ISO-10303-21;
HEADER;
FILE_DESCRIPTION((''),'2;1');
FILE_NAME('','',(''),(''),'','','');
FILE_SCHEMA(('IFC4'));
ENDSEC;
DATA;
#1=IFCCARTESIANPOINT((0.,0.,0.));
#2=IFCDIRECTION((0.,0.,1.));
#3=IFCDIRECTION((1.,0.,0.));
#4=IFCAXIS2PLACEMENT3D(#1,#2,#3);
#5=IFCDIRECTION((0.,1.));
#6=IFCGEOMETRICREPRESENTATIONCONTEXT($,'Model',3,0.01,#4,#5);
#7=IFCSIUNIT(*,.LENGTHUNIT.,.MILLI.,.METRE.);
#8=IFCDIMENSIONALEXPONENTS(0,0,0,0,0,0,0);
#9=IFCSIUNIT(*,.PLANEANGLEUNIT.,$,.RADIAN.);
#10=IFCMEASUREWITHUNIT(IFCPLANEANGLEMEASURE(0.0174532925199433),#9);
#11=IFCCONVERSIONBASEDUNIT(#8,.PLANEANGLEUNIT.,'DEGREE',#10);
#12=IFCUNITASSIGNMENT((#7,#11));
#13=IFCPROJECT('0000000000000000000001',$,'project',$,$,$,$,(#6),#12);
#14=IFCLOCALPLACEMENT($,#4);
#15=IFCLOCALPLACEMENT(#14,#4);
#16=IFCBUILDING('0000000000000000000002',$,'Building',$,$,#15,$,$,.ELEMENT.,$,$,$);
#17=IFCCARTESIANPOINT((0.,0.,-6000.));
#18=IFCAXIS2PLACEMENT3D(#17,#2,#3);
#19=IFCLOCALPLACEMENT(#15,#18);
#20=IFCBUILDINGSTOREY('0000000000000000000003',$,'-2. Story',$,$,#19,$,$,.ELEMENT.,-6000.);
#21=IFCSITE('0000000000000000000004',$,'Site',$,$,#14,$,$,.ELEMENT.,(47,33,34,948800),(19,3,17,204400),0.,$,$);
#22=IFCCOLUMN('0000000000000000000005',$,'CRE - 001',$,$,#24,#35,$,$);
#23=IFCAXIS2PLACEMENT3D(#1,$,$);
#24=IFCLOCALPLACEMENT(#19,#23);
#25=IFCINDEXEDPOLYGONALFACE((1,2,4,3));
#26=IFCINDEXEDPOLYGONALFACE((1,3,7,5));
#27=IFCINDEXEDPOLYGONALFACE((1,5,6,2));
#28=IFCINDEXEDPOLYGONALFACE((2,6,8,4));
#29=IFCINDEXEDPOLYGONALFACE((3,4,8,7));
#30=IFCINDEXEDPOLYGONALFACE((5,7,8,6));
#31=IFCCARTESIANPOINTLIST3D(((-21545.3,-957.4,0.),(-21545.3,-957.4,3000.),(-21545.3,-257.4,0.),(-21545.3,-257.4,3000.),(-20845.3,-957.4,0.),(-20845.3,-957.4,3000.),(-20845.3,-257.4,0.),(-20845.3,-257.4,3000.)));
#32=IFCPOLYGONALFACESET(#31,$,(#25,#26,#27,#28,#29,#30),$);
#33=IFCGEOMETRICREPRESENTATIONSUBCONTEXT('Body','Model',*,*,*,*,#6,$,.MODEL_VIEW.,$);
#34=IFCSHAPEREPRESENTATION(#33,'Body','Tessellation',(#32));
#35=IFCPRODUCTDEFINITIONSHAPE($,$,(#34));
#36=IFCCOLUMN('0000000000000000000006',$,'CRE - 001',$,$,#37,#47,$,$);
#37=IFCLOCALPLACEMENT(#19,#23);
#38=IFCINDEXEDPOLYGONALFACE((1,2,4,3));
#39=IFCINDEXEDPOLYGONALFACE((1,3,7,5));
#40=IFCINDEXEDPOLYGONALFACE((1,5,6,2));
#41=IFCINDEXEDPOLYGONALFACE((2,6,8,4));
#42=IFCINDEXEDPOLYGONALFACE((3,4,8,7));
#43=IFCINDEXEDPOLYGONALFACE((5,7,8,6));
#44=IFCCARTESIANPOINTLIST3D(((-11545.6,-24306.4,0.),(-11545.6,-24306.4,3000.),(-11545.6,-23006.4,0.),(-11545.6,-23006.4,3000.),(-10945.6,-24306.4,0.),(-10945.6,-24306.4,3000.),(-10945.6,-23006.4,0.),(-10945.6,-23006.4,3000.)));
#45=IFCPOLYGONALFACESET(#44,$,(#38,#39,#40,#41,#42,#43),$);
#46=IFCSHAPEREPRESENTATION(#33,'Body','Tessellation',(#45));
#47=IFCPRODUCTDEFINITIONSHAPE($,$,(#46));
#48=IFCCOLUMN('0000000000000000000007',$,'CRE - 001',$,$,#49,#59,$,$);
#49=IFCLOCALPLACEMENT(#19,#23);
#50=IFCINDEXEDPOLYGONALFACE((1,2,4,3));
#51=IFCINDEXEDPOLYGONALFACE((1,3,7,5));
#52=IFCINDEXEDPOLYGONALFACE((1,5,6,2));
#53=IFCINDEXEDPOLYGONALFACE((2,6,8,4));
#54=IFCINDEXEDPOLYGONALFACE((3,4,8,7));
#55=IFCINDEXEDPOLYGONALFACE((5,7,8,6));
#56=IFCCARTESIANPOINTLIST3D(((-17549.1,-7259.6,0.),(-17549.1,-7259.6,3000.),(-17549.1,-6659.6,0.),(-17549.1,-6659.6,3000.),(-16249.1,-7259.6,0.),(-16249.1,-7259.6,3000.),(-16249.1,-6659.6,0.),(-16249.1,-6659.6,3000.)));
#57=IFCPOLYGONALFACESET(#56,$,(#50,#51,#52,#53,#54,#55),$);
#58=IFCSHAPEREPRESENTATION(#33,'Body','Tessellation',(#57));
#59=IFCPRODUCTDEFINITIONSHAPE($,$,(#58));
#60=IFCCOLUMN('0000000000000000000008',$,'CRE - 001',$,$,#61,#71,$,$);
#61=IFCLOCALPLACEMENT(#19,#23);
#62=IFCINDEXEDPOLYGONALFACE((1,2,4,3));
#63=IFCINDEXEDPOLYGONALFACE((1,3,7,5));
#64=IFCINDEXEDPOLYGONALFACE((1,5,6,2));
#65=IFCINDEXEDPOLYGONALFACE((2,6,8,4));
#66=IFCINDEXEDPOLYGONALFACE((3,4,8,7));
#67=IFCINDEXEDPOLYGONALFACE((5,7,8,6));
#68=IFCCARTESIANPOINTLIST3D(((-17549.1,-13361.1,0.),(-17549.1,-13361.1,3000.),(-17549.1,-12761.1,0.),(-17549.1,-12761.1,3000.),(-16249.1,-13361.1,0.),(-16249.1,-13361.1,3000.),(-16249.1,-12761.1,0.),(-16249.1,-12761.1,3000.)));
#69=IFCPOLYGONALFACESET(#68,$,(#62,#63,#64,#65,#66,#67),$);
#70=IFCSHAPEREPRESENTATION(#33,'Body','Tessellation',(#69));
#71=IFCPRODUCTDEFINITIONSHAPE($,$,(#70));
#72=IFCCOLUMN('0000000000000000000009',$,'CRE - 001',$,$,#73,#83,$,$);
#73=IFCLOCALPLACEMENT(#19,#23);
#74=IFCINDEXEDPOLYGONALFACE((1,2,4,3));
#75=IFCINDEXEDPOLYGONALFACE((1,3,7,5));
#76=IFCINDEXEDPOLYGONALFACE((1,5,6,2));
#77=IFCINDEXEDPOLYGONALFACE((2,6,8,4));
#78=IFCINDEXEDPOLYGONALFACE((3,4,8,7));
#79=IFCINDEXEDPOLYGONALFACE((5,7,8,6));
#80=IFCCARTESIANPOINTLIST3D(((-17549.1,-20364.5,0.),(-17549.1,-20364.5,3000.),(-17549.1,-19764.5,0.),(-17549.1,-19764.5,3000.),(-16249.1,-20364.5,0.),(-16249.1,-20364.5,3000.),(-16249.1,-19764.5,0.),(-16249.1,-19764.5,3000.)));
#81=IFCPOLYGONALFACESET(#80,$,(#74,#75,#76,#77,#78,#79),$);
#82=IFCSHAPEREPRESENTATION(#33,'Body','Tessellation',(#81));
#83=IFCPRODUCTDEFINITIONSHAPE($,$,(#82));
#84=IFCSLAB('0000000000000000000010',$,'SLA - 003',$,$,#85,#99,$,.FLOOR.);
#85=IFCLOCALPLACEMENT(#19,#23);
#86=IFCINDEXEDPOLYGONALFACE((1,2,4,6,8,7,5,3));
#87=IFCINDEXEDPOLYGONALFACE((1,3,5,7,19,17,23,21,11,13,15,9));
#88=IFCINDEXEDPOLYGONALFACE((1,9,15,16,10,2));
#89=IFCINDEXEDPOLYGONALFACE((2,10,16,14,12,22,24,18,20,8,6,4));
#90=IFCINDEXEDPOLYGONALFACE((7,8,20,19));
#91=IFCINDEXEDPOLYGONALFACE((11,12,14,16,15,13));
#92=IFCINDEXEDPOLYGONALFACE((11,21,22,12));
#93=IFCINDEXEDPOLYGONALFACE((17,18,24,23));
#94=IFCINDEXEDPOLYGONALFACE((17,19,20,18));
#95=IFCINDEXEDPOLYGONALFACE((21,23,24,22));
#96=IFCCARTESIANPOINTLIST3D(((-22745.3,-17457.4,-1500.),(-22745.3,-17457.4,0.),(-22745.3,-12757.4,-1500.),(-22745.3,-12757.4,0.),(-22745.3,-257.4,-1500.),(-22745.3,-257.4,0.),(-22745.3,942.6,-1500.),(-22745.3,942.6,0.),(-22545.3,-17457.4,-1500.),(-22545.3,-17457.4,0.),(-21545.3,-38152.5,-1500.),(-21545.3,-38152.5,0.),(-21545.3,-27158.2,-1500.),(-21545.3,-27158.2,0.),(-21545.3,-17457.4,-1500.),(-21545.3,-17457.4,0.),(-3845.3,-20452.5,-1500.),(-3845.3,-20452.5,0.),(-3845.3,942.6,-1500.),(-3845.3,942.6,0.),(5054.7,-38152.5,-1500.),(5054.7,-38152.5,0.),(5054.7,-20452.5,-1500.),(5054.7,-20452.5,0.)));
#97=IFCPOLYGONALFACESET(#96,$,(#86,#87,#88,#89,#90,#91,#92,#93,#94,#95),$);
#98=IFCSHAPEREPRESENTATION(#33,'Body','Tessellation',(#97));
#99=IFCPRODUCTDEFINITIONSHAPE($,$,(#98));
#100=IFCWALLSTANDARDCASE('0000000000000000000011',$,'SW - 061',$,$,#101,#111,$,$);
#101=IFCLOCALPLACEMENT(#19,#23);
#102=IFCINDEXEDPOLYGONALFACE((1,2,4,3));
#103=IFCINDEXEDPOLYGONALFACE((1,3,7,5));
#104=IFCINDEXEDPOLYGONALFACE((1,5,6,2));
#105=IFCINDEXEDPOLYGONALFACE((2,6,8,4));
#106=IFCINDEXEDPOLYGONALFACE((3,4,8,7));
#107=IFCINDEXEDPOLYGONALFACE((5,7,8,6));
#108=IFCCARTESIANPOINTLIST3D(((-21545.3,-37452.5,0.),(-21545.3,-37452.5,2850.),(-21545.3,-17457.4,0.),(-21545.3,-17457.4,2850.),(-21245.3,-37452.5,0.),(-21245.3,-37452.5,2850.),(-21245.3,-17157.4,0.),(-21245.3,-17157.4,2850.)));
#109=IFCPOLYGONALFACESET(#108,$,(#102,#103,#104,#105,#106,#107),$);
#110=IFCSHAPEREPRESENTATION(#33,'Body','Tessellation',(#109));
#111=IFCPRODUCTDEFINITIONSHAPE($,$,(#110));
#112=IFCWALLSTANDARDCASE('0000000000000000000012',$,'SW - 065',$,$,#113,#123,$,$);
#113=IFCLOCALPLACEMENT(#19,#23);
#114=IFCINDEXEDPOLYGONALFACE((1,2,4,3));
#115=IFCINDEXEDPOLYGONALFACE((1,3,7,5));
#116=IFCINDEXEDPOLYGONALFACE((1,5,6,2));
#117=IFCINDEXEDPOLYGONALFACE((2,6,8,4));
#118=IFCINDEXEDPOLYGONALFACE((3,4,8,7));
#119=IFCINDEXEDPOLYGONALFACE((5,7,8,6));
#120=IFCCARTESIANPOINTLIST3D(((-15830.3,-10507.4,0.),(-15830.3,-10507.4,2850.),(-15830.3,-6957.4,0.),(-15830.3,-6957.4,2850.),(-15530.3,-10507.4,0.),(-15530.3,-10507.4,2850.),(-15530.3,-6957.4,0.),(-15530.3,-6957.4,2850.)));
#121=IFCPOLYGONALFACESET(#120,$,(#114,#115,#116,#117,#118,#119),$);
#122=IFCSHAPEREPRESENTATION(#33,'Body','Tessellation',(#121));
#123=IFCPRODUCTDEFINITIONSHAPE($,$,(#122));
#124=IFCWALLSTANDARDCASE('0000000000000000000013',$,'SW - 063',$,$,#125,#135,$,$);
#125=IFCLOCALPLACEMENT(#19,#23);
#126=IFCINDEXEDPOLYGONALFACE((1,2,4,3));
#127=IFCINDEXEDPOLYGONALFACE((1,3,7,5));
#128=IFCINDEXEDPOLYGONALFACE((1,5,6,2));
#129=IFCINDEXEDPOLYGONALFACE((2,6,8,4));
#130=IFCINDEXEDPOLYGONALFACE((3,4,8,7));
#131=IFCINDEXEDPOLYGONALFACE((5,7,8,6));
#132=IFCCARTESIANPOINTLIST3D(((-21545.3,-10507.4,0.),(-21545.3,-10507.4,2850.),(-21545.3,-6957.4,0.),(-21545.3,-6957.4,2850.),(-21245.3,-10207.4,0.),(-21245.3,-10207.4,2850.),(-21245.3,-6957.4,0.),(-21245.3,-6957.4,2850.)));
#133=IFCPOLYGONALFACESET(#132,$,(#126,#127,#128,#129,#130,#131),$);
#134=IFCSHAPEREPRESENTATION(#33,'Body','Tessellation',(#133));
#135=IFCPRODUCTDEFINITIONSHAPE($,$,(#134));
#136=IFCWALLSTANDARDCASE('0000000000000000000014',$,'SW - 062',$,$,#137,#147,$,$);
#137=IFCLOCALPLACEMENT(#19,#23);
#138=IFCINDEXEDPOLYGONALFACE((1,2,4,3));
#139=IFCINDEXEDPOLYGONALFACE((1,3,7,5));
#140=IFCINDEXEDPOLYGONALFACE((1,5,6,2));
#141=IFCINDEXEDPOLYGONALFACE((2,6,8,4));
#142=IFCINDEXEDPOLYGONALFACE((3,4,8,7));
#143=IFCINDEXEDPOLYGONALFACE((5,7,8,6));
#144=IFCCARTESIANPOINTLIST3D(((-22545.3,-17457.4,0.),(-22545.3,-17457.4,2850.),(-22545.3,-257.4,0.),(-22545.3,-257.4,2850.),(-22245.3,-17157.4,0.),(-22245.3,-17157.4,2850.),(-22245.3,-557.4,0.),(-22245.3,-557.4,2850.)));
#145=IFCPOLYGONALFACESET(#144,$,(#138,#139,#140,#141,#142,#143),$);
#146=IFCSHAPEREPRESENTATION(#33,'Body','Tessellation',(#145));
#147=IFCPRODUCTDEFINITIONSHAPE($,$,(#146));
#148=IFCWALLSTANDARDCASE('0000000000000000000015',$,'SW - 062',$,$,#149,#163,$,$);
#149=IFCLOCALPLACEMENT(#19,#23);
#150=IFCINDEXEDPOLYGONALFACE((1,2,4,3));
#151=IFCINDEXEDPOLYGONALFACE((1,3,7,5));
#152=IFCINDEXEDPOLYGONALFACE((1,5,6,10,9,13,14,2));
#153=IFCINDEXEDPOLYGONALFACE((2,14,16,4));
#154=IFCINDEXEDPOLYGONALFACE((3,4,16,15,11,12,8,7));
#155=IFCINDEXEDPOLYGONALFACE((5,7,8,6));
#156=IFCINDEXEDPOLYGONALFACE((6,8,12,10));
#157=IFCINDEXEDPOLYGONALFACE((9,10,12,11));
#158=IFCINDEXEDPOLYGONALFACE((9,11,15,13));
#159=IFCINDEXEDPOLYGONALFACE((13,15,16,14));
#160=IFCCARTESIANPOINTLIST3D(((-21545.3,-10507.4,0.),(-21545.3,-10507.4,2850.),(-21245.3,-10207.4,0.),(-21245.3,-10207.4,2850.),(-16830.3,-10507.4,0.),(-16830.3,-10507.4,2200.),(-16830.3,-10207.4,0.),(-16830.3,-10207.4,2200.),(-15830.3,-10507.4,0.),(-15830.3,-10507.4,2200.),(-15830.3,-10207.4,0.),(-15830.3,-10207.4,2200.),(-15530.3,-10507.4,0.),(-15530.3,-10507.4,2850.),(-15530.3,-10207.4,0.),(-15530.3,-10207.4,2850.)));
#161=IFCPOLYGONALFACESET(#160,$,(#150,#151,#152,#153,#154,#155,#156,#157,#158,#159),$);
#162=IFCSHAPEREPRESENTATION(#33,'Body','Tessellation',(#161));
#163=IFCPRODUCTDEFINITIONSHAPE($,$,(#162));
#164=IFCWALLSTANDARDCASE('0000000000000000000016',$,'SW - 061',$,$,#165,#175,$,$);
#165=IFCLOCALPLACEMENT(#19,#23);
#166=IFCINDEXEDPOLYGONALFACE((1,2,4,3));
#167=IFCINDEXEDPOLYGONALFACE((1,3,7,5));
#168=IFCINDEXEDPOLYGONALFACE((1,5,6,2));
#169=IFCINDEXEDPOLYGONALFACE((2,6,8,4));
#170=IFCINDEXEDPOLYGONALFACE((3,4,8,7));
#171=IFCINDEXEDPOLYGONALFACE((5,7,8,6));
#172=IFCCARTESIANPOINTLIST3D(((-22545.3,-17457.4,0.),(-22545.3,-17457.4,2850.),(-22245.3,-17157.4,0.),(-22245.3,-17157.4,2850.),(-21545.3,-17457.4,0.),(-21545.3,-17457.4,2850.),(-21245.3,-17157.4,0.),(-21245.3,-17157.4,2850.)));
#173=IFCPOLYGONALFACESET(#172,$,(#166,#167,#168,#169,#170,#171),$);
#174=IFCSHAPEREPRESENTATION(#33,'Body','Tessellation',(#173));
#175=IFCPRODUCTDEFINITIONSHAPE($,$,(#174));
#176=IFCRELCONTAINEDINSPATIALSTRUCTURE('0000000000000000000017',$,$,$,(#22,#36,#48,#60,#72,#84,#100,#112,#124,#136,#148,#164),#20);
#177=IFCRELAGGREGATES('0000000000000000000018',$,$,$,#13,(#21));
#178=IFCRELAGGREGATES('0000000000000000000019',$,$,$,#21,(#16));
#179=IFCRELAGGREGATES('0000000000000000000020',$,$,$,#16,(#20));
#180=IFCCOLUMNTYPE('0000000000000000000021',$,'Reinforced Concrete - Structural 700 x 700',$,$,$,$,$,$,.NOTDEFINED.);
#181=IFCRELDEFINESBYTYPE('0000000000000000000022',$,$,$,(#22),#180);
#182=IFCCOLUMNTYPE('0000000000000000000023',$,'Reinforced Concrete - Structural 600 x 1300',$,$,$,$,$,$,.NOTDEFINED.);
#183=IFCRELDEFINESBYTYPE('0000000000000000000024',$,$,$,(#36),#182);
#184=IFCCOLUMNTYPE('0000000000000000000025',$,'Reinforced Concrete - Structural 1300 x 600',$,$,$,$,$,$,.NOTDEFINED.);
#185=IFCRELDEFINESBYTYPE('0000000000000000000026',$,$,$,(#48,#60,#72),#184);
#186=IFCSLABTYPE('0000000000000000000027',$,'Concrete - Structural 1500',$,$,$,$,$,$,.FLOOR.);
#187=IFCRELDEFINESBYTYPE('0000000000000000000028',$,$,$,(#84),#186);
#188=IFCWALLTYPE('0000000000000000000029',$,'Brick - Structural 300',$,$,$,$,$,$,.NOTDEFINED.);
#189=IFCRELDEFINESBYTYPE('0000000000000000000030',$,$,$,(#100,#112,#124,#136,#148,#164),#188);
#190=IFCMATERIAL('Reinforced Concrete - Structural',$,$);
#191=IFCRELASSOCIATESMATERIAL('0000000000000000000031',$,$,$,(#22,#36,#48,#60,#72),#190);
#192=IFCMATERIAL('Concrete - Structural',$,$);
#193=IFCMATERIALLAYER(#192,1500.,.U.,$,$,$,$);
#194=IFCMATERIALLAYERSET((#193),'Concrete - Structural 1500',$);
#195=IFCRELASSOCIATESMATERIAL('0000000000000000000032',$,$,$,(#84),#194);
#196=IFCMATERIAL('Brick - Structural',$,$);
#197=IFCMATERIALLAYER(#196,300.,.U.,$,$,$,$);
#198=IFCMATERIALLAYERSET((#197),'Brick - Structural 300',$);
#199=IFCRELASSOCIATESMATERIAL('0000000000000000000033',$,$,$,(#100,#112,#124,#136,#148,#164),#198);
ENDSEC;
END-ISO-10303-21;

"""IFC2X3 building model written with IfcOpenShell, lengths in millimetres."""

from ifc_helpers import new_model, entity, si_unit, converted_unit, direction, frame, origin_with_axes, origin_2d_with_axis, place, context, subcontext, project, spatial, polyline, rectangle, outline, extrude, material, layer, layer_set, layer_usage, type_object, element, save


model = new_model("IFC2X3")

# Units and contexts
model_context = context("Model", 3, precision=0.01, world=origin_with_axes(), true_north=direction((0.0, 1.0)))
body_context = subcontext(model_context, "Body", "Model", "MODEL_VIEW")
ifc_project = project(units=[si_unit("LENGTHUNIT", "METRE", prefix="MILLI"), converted_unit("PLANEANGLEUNIT", "DEGREE", entity("IfcPlaneAngleMeasure", 0.0174532925199433), si_unit("PLANEANGLEUNIT", "RADIAN"), dimensions=[0, 0, 0, 0, 0, 0, 0])], contexts=[model_context])

# Site, building, storey
site_placement = place(None, origin_with_axes())
site = spatial("IfcSite", under=ifc_project, at=site_placement, Name="Site", CompositionType="ELEMENT", RefLatitude=(47, 33, 34, 948800), RefLongitude=(19, 3, 17, 204400), RefElevation=0.0)
building_placement = place(site_placement, origin_with_axes())
building = spatial("IfcBuilding", under=site, at=building_placement, Name="Building", CompositionType="ELEMENT")
storey_placement = place(building_placement, frame((0.0, 0.0, -6000.0), z_axis=(0.0, 0.0, 1.0), x_axis=(1.0, 0.0, 0.0)))
storey = spatial("IfcBuildingStorey", under=building, at=storey_placement, Name="-2. Story", CompositionType="ELEMENT", Elevation=-6000.0)

# Columns
ifc_material_1 = material(Name="Reinforced Concrete - Structural")
column_type_1 = type_object("IfcColumnType", Name="Reinforced Concrete - Structural 700 x 700", PredefinedType="NOTDEFINED")
column_1_placement = place(storey_placement, frame((-21195.3, -607.4, 0.0), z_axis=(0.0, 0.0, 1.0), x_axis=(1.0, 0.0, 0.0)))
element("IfcColumn", 1, at=column_1_placement, inside=storey, type_object=column_type_1, material=ifc_material_1, Name="CRE - 001", context=body_context, shape_type="SweptSolid", body=[
    extrude(rectangle(XDim=700.0, YDim=700.0, at=origin_2d_with_axis()), origin_with_axes(), (0.0, 0.0, 1.0), 3000.0),
])
column_type_2 = type_object("IfcColumnType", Name="Reinforced Concrete - Structural 600 x 1300", PredefinedType="NOTDEFINED")
column_2_placement = place(storey_placement, frame((-11245.6, -23656.4, 0.0), z_axis=(0.0, 0.0, 1.0), x_axis=(1.0, 0.0, 0.0)))
element("IfcColumn", 2, at=column_2_placement, inside=storey, type_object=column_type_2, material=ifc_material_1, Name="CRE - 001", context=body_context, shape_type="SweptSolid", body=[
    extrude(rectangle(XDim=600.0, YDim=1300.0, at=origin_2d_with_axis()), origin_with_axes(), (0.0, 0.0, 1.0), 3000.0),
])
column_type_3 = type_object("IfcColumnType", Name="Reinforced Concrete - Structural 1300 x 600", PredefinedType="NOTDEFINED")
for number, where, z_axis, x_axis, name in (
    (3, (-16899.1, -6959.6, 0.0), (0.0, 0.0, 1.0), (1.0, 0.0, 0.0), "CRE - 001"),
    (4, (-16899.1, -13061.1, 0.0), (0.0, 0.0, 1.0), (1.0, 0.0, 0.0), "CRE - 001"),
    (5, (-16899.1, -20064.5, 0.0), (0.0, 0.0, 1.0), (1.0, 0.0, 0.0), "CRE - 001"),
):
    element("IfcColumn", number, at=place(storey_placement, frame(where, z_axis=z_axis, x_axis=x_axis)), inside=storey, type_object=column_type_3, material=ifc_material_1, Name=name, context=body_context, shape_type="SweptSolid", body=[
        extrude(rectangle(XDim=1300.0, YDim=600.0, at=origin_2d_with_axis()), origin_with_axes(), (0.0, 0.0, 1.0), 3000.0),
    ])

# Slab
ifc_material_2 = material(Name="Concrete - Structural")
ifc_layer_1 = layer(ifc_material_2, 1500.0, ventilated="UNKNOWN")
ifc_layer_set_1 = layer_set([ifc_layer_1], Name="Concrete - Structural 1500")
ifc_layer_usage_1 = layer_usage(ifc_layer_set_1, "AXIS3", "NEGATIVE", 1500.0)
slab_type = type_object("IfcSlabType", Name="Concrete - Structural 1500", PredefinedType="FLOOR")
slab_placement = place(storey_placement, frame((-22745.3, -17457.4, 0.0), z_axis=(0.0, 0.0, 1.0), x_axis=(1.0, 0.0, 0.0)))
element("IfcSlab", 6, at=slab_placement, inside=storey, type_object=slab_type, material=ifc_layer_usage_1, Name="SLA - 003", PredefinedType="FLOOR", context=body_context, shape_type="SweptSolid", body=[
    extrude(outline(polyline([(0.0, 0.0), (200.0, 0.0), (1200.0, 0.0), (1200.0, -9700.8), (1200.0, -20695.1), (27800.0, -20695.1), (27800.0, -2995.1), (18900.0, -2995.1), (18900.0, 18400.0), (0.0, 18400.0), (0.0, 17200.0), (0.0, 4700.0), (0.0, 0.0)])), frame((0.0, 0.0, -1500.0), z_axis=(0.0, 0.0, 1.0), x_axis=(1.0, 0.0, 0.0)), (0.0, 0.0, 1.0), 1500.0),
])

# Walls
ifc_material_3 = material(Name="Brick - Structural")
ifc_layer_2 = layer(ifc_material_3, 300.0, ventilated="UNKNOWN")
ifc_layer_set_2 = layer_set([ifc_layer_2], Name="Brick - Structural 300")
ifc_layer_usage_2 = layer_usage(ifc_layer_set_2, "AXIS2", "POSITIVE", 0.0)
wall_type_1 = type_object("IfcWallType", Name="Brick - Structural 300", PredefinedType="NOTDEFINED")
wall_1_placement = place(storey_placement, frame((-21545.3, -17457.4, 0.0), z_axis=(0.0, 0.0, 1.0), x_axis=(0.0, -1.0, 0.0)))
element("IfcWallStandardCase", 7, at=wall_1_placement, inside=storey, type_object=wall_type_1, material=ifc_layer_usage_2, Name="SW - 061", context=body_context, shape_type="SweptSolid", body=[
    extrude(outline(polyline([(0.0, 0.0), (19995.1, 0.0), (19995.1, 300.0), (-300.0, 300.0), (0.0, 0.0)])), origin_with_axes(), (0.0, 0.0, 1.0), 2850.0),
])
ifc_layer_usage_3 = layer_usage(ifc_layer_set_2, "AXIS2", "NEGATIVE", 0.0)
wall_2_placement = place(storey_placement, frame((-15530.3, -6957.4, 0.0), z_axis=(0.0, 0.0, 1.0), x_axis=(0.0, -1.0, 0.0)))
element("IfcWallStandardCase", 8, at=wall_2_placement, inside=storey, type_object=wall_type_1, material=ifc_layer_usage_3, Name="SW - 065", context=body_context, shape_type="SweptSolid", body=[
    extrude(outline(polyline([(0.0, -300.0), (3550.0, -300.0), (3550.0, 0.0), (0.0, 0.0), (0.0, -300.0)])), origin_with_axes(), (0.0, 0.0, 1.0), 2850.0),
])
ifc_layer_usage_4 = layer_usage(ifc_layer_set_2, "AXIS2", "NEGATIVE", 0.0)
wall_3_placement = place(storey_placement, frame((-21545.3, -10507.4, 0.0), z_axis=(0.0, 0.0, 1.0), x_axis=(0.0, 1.0, 0.0)))
element("IfcWallStandardCase", 9, at=wall_3_placement, inside=storey, type_object=wall_type_1, material=ifc_layer_usage_4, Name="SW - 063", context=body_context, shape_type="SweptSolid", body=[
    extrude(outline(polyline([(300.0, -300.0), (3550.0, -300.0), (3550.0, 0.0), (0.0, 0.0), (300.0, -300.0)])), origin_with_axes(), (0.0, 0.0, 1.0), 2850.0),
])
ifc_layer_usage_5 = layer_usage(ifc_layer_set_2, "AXIS2", "NEGATIVE", 0.0)
wall_4_placement = place(storey_placement, frame((-22545.3, -17457.4, 0.0), z_axis=(0.0, 0.0, 1.0), x_axis=(0.0, 1.0, 0.0)))
element("IfcWallStandardCase", 10, at=wall_4_placement, inside=storey, type_object=wall_type_1, material=ifc_layer_usage_5, Name="SW - 062", context=body_context, shape_type="SweptSolid", body=[
    extrude(outline(polyline([(300.0, -300.0), (16900.0, -300.0), (17200.0, 0.0), (0.0, 0.0), (300.0, -300.0)])), origin_with_axes(), (0.0, 0.0, 1.0), 2850.0),
])

# Wall, opening
ifc_layer_usage_6 = layer_usage(ifc_layer_set_2, "AXIS2", "NEGATIVE", 0.0)
wall_5_placement = place(storey_placement, frame((-15530.3, -10507.4, 0.0), z_axis=(0.0, 0.0, 1.0), x_axis=(-1.0, 0.0, 0.0)))
wall_5 = element("IfcWallStandardCase", 11, at=wall_5_placement, inside=storey, type_object=wall_type_1, material=ifc_layer_usage_6, Name="SW - 062", context=body_context, shape_type="SweptSolid", body=[
    extrude(outline(polyline([(0.0, -300.0), (5715.0, -300.0), (6015.0, 0.0), (0.0, 0.0), (0.0, -300.0)])), origin_with_axes(), (0.0, 0.0, 1.0), 2850.0),
])
opening_1_placement = place(wall_5_placement, frame((800.0, 0.0, 0.0), z_axis=(0.0, 0.0, 1.0), x_axis=(1.0, 0.0, 0.0)))
element("IfcOpeningElement", 12, at=opening_1_placement, cuts=wall_5, context=body_context, shape_type="SweptSolid", body=[
    extrude(rectangle(XDim=1000.0, YDim=2200.0, at=origin_2d_with_axis()), frame((0.0, 0.0, 1100.0), z_axis=(0.0, -1.0, 0.0), x_axis=(1.0, 0.0, 0.0)), (0.0, 0.0, -1.0), 300.0),
    extrude(rectangle(XDim=1000.0, YDim=2200.0, at=origin_2d_with_axis()), frame((0.0, 0.0, 1100.0), z_axis=(0.0, 1.0, 0.0), x_axis=(1.0, 0.0, 0.0)), (0.0, 0.0, -1.0), 300.0),
])

# Wall
ifc_layer_usage_7 = layer_usage(ifc_layer_set_2, "AXIS2", "NEGATIVE", 0.0)
wall_6_placement = place(storey_placement, frame((-21545.3, -17457.4, 0.0), z_axis=(0.0, 0.0, 1.0), x_axis=(-1.0, 0.0, 0.0)))
element("IfcWallStandardCase", 13, at=wall_6_placement, inside=storey, type_object=wall_type_1, material=ifc_layer_usage_7, Name="SW - 061", context=body_context, shape_type="SweptSolid", body=[
    extrude(outline(polyline([(-300.0, -300.0), (700.0, -300.0), (1000.0, 0.0), (0.0, 0.0), (-300.0, -300.0)])), origin_with_axes(), (0.0, 0.0, 1.0), 2850.0),
])

save(model, "model.ifc")
